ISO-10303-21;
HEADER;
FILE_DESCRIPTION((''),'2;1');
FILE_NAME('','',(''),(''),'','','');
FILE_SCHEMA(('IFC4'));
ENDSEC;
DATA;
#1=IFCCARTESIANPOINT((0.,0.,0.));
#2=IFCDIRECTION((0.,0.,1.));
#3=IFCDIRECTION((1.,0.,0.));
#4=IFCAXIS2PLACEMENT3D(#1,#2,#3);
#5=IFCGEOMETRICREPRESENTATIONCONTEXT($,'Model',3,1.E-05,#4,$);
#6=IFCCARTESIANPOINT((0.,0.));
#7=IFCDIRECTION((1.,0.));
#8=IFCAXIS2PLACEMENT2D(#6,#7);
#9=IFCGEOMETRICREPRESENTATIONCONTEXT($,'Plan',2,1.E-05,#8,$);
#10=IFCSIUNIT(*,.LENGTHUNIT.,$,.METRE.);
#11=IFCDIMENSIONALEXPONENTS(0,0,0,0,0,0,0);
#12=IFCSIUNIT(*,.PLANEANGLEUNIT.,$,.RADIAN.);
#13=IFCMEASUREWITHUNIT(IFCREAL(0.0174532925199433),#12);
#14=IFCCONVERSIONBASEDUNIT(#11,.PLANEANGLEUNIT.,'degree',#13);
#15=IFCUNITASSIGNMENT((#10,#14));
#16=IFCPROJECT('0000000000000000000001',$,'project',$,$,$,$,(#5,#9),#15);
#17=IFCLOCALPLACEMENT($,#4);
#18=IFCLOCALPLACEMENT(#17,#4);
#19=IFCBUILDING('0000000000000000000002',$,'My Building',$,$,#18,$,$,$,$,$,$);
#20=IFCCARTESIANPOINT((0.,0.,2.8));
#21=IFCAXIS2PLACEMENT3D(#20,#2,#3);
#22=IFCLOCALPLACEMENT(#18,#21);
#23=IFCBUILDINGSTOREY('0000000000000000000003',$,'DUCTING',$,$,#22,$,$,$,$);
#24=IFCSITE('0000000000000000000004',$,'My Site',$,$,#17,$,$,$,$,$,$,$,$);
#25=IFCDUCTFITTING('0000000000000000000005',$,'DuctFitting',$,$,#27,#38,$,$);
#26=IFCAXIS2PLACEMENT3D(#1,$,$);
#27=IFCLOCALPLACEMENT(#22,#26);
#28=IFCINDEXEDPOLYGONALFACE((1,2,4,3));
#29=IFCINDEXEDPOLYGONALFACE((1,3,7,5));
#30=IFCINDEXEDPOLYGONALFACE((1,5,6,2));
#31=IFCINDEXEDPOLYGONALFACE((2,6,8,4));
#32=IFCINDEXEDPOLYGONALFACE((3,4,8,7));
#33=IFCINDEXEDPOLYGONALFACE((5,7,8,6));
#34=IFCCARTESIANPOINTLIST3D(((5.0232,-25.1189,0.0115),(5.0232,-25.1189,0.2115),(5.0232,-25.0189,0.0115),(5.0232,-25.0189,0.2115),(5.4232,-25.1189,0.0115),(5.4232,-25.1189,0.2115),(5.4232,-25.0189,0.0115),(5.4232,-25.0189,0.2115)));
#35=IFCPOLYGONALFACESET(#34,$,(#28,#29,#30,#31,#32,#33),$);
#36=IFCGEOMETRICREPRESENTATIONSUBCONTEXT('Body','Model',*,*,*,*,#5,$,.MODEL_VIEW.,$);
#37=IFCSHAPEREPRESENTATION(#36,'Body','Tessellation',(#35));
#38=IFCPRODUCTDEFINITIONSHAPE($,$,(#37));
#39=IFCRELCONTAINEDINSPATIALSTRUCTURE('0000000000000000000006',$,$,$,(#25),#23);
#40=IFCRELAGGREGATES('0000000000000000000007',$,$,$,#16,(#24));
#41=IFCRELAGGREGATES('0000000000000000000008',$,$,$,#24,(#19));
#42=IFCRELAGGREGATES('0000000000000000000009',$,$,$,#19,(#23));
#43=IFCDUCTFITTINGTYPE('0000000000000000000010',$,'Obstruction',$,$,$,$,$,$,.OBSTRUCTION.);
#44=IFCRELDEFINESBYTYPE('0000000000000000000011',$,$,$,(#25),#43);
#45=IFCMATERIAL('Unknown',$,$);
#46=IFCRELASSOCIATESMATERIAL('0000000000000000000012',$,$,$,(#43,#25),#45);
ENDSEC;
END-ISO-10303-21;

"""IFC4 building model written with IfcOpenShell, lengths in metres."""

from ifc_helpers import new_model, entity, si_unit, converted_unit, frame, origin_with_axes, origin_2d_with_axis, place, context, subcontext, project, spatial, rectangle, extrude, material, material_profile, profile_set, profile_usage, type_object, element, save


model = new_model("IFC4")

# Units and contexts
model_context = context("Model", 3, precision=1e-05, world=origin_with_axes())
plan_context = context("Plan", 2, precision=1e-05, world=origin_2d_with_axis())
body_context = subcontext(model_context, "Body", "Model", "MODEL_VIEW")
ifc_project = project(units=[si_unit("LENGTHUNIT", "METRE"), converted_unit("PLANEANGLEUNIT", "degree", entity("IfcReal", 0.0174532925199433), si_unit("PLANEANGLEUNIT", "RADIAN"), dimensions=[0, 0, 0, 0, 0, 0, 0])], contexts=[model_context, plan_context])

# Site, building, storey
site_placement = place(None, origin_with_axes())
site = spatial("IfcSite", under=ifc_project, at=site_placement, Name="My Site")
building_placement = place(site_placement, origin_with_axes())
building = spatial("IfcBuilding", under=site, at=building_placement, Name="My Building")
storey_placement = place(building_placement, frame((0.0, 0.0, 2.8), z_axis=(0.0, 0.0, 1.0), x_axis=(1.0, 0.0, 0.0)))
storey = spatial("IfcBuildingStorey", under=building, at=storey_placement, Name="DUCTING")

# Shared definitions
ifc_material = material(Name="Unknown")

# Duct fitting
ifc_material_profile_1 = material_profile(ifc_material, rectangle(XDim=0.4, YDim=0.2))
ifc_profile_set_1 = profile_set([ifc_material_profile_1])
duct_fitting_type_1 = type_object("IfcDuctFittingType", Name="Obstruction", PredefinedType="OBSTRUCTION", material=ifc_profile_set_1)
ifc_profile_usage_1 = profile_usage(ifc_profile_set_1, cardinal=5)
duct_fitting_1_placement = place(storey_placement, frame((5.2232, -25.0189, 0.1115), z_axis=(0.0, -1.0, 0.0), x_axis=(1.0, 0.0, 0.0)))
element("IfcDuctFitting", 1, at=duct_fitting_1_placement, inside=storey, type_object=duct_fitting_type_1, material=ifc_profile_usage_1, Name="DuctFitting", context=body_context, shape_type="SweptSolid", body=[
    extrude(rectangle(XDim=0.4, YDim=0.2), origin_with_axes(), (0.0, 0.0, 1.0), 0.1),
])

save(model, "model.ifc")
